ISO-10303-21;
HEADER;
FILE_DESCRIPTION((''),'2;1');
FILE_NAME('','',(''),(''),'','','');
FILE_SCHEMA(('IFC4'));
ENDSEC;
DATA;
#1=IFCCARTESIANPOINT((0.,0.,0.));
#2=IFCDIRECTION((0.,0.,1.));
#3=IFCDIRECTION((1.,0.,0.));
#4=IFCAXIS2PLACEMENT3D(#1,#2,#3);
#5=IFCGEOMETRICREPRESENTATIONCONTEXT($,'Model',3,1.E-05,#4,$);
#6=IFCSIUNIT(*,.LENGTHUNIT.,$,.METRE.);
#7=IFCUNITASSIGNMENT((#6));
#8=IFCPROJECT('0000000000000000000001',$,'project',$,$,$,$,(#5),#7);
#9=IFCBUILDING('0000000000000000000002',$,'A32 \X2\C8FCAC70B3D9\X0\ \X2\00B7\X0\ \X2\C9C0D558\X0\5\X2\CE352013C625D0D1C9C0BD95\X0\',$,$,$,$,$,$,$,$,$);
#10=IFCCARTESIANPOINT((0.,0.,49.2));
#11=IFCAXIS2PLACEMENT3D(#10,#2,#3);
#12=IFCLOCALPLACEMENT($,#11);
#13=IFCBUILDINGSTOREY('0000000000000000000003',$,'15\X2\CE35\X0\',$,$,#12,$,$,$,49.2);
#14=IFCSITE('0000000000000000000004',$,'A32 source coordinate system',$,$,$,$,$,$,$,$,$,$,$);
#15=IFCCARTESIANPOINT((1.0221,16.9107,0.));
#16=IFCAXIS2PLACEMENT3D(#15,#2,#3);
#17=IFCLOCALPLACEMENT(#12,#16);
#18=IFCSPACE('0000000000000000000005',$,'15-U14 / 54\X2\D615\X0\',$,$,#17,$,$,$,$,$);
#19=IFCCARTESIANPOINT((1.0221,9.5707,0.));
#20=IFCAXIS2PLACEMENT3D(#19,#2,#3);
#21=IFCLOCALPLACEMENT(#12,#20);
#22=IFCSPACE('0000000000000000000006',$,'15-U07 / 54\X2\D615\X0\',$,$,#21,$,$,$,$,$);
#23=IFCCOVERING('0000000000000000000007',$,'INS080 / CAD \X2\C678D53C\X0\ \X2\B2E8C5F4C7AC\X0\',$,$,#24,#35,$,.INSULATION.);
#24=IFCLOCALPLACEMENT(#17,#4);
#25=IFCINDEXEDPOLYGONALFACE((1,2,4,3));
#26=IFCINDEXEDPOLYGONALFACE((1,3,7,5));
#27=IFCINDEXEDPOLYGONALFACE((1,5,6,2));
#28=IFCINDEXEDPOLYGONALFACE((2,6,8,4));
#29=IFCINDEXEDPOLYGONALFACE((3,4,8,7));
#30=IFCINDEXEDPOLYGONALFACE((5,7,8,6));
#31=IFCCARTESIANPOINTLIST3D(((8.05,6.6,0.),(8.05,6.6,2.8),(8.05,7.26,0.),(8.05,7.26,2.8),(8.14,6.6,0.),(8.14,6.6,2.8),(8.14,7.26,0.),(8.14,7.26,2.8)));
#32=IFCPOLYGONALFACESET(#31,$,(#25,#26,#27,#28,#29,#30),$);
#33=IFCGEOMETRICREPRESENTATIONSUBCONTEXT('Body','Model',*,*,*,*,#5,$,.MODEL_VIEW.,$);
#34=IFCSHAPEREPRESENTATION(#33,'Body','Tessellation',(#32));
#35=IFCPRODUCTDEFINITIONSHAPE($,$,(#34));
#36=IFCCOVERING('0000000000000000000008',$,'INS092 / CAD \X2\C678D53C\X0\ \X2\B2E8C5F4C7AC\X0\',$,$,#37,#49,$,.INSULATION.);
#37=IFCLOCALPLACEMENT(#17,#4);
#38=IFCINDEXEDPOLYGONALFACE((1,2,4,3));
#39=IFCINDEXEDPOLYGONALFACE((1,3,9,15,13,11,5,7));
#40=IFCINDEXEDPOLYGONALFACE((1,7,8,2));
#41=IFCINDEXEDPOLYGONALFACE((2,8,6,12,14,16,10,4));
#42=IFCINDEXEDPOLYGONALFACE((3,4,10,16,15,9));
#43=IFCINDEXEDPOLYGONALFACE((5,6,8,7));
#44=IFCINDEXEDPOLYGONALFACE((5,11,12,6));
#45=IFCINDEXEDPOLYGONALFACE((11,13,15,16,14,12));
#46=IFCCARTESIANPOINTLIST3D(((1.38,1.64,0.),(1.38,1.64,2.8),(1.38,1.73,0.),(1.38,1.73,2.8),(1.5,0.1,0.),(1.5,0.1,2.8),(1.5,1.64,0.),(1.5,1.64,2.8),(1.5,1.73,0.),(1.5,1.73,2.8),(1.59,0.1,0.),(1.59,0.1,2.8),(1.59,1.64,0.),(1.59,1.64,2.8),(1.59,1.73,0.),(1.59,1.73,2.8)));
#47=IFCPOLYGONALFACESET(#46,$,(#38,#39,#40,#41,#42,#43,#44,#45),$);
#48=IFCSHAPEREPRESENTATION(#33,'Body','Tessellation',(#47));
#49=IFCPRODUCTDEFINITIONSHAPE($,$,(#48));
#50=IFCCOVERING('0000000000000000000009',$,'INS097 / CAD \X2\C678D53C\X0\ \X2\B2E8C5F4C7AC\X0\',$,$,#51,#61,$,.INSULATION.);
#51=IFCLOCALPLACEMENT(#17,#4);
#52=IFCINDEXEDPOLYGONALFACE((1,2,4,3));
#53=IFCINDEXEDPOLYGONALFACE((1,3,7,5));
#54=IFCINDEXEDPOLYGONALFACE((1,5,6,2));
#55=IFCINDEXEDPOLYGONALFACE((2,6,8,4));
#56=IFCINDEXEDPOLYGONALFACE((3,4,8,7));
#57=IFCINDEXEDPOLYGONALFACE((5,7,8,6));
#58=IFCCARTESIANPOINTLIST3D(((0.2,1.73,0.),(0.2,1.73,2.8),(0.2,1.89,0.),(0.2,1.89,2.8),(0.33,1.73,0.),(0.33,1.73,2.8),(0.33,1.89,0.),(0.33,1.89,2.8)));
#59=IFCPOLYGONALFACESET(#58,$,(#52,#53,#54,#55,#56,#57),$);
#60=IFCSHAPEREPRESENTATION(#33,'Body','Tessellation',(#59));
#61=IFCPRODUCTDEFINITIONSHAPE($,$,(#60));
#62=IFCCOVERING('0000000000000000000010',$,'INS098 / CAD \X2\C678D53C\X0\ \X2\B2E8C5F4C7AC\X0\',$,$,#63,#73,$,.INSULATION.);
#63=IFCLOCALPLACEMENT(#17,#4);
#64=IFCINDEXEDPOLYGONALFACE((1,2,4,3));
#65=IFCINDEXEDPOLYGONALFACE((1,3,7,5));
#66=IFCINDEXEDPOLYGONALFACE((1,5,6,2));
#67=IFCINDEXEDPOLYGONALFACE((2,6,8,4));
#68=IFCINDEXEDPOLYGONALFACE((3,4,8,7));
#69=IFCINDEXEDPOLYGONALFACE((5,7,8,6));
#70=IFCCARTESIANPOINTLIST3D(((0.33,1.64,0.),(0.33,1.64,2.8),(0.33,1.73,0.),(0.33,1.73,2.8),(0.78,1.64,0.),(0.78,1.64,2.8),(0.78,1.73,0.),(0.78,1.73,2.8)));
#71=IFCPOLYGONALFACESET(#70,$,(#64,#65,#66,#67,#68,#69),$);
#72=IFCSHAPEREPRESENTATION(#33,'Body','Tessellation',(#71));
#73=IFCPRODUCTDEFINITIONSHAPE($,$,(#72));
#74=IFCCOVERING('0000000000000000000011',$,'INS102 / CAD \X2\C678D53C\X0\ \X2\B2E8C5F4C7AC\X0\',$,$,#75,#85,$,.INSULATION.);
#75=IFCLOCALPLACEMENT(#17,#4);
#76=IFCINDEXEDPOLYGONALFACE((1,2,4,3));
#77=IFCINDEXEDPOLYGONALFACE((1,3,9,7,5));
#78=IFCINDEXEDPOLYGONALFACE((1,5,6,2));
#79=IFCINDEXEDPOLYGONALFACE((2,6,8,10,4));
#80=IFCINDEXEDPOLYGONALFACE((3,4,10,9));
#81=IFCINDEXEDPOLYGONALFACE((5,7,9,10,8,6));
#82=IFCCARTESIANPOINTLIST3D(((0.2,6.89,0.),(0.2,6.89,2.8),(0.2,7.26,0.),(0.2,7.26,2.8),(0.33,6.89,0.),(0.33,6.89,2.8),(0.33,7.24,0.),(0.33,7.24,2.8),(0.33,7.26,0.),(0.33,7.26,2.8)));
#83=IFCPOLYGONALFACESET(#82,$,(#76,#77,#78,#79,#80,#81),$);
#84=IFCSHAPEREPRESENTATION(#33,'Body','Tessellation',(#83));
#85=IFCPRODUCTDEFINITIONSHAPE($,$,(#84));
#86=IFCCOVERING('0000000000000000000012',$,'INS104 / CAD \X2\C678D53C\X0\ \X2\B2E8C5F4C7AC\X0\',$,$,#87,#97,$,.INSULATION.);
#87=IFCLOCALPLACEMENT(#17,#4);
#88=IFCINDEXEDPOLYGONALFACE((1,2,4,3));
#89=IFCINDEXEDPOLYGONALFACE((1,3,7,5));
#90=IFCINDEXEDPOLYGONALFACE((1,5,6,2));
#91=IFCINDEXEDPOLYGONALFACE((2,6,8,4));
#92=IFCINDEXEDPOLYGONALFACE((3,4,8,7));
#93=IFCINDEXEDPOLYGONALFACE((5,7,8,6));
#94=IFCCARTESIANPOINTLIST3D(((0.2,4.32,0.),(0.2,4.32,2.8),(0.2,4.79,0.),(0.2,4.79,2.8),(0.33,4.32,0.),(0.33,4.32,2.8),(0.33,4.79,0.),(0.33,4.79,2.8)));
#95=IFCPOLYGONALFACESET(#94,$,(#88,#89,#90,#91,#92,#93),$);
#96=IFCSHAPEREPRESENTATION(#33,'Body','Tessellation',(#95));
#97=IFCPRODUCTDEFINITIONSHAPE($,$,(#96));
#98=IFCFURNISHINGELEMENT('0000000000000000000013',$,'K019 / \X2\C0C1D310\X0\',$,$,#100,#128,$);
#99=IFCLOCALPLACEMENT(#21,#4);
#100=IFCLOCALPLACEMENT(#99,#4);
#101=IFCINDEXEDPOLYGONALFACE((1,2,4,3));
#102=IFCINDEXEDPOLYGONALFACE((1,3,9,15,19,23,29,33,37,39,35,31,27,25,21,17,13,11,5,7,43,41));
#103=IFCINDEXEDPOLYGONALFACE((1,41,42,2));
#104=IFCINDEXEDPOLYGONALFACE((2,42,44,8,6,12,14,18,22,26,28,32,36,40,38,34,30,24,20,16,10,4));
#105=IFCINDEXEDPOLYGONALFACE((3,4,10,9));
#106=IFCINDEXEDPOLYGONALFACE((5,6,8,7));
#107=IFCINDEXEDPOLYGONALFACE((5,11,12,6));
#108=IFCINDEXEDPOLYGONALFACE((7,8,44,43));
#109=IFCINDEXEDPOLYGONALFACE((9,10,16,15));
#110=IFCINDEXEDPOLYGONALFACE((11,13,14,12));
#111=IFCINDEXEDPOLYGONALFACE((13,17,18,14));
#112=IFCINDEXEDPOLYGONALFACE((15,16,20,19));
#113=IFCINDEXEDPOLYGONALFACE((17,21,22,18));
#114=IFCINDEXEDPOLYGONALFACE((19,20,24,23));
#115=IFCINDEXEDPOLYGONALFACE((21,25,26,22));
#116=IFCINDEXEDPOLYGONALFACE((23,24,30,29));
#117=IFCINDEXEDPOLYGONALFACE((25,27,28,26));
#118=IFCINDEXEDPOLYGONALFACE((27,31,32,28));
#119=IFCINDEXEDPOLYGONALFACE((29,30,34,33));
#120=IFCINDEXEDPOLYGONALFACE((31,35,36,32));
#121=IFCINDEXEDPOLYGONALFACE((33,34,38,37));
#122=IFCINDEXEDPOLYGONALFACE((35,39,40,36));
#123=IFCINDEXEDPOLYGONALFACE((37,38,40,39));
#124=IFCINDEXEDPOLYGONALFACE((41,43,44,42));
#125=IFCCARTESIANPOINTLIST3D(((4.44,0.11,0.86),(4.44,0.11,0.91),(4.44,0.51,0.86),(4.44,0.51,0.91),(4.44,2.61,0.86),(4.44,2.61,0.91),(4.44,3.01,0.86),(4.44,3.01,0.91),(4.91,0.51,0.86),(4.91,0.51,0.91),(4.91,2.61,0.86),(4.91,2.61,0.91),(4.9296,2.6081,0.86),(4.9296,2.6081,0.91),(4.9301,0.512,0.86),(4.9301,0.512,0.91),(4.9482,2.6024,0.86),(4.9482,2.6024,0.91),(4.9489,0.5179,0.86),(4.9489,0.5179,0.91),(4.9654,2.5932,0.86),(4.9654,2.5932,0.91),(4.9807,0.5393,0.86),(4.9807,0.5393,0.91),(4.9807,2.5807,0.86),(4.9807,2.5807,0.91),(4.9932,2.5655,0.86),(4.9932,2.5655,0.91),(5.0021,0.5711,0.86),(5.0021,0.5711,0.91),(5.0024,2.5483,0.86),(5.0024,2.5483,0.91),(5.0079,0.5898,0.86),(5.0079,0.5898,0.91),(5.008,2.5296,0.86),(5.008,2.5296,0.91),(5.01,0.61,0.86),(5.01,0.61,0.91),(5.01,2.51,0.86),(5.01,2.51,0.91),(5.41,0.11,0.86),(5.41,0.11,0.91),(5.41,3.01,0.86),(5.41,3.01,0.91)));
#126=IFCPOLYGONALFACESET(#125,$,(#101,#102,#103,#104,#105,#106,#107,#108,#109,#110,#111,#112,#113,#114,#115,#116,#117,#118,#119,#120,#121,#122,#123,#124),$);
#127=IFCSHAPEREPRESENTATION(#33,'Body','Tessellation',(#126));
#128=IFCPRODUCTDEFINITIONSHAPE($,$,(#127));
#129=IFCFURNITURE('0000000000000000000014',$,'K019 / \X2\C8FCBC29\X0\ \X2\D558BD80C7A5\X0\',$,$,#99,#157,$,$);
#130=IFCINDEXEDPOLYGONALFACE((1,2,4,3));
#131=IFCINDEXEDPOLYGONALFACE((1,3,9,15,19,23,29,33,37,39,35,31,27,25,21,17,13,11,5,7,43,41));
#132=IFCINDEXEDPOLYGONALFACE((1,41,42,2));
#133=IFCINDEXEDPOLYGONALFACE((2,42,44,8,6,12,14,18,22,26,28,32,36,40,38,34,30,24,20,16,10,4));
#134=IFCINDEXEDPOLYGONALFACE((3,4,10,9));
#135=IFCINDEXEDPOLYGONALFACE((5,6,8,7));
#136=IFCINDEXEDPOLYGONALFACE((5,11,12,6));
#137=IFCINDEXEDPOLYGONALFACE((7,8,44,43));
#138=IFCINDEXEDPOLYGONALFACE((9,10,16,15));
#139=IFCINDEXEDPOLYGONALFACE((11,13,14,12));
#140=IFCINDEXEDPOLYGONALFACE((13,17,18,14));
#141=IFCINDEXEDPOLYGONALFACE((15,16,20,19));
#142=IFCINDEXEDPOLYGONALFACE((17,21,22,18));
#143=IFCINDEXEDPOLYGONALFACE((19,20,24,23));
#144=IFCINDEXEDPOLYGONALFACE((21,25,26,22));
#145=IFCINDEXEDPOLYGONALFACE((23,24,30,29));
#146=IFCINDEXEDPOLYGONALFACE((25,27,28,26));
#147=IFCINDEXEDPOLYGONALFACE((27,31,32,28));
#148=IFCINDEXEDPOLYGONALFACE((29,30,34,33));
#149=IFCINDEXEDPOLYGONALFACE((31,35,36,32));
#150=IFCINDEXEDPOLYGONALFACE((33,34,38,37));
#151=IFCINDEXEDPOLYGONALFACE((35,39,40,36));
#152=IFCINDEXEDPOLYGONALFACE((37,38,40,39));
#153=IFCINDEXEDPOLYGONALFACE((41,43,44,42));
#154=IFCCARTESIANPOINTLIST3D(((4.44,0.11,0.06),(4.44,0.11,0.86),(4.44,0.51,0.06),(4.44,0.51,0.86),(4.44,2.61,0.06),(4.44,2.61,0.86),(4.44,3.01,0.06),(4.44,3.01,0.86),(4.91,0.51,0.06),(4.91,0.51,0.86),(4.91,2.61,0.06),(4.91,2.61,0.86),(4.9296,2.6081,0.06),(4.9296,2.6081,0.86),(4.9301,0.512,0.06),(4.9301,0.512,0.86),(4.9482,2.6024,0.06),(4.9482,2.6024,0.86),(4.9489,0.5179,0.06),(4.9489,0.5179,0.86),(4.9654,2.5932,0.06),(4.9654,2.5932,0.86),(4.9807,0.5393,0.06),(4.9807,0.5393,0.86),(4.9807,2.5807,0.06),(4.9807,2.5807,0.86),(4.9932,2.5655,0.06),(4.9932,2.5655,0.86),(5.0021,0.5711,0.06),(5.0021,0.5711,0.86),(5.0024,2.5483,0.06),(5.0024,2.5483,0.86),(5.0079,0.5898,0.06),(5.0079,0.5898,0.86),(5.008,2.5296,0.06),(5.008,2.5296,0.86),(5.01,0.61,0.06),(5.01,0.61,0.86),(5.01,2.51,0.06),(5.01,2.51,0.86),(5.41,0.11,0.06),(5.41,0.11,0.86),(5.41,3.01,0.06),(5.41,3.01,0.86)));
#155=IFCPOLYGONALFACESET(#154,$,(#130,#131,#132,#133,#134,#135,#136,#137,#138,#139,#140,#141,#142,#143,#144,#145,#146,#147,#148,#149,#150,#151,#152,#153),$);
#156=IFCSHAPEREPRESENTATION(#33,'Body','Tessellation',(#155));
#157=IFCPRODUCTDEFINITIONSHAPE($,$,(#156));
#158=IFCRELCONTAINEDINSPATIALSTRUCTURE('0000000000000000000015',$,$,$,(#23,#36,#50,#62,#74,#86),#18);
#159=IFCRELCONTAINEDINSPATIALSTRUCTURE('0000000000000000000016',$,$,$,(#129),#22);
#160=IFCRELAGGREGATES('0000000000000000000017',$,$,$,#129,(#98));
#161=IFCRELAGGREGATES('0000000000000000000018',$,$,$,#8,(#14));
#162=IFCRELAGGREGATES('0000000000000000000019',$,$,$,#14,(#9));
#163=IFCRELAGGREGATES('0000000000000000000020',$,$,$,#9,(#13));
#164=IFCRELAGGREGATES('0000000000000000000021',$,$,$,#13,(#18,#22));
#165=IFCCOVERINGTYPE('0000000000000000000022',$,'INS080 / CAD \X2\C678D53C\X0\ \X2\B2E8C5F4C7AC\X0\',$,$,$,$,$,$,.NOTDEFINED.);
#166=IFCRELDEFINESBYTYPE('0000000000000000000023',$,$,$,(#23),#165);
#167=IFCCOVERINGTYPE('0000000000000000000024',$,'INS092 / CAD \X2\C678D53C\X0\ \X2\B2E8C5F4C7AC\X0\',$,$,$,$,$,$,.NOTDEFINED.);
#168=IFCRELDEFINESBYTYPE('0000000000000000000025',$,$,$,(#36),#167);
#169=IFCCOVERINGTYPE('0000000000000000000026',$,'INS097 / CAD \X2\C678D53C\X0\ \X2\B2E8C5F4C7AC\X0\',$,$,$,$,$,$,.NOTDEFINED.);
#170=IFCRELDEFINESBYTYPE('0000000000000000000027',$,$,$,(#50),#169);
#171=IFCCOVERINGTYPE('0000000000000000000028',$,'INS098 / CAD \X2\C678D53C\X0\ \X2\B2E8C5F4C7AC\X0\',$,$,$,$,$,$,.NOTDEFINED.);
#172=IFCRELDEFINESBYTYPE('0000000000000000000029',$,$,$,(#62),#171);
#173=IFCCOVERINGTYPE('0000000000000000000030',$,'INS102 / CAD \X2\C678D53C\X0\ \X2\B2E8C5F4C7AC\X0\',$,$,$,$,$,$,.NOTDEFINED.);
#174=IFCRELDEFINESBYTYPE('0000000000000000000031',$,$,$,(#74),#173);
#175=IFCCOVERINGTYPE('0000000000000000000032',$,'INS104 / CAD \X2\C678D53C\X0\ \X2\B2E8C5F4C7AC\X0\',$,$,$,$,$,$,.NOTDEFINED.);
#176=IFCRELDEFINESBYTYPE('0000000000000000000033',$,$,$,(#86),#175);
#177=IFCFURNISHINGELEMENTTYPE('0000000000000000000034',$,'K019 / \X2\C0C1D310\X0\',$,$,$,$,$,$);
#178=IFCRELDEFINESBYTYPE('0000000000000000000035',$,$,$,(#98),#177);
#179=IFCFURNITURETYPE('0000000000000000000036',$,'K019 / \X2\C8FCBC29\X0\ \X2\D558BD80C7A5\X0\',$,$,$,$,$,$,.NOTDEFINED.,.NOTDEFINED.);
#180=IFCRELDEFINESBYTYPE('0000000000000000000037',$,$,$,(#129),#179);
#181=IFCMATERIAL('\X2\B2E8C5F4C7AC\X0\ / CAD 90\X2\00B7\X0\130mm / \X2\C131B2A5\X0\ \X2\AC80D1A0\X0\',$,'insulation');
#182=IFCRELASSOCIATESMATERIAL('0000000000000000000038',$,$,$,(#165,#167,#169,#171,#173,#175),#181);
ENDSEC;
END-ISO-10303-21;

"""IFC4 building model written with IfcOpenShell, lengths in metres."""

from ifc_helpers import new_model, si_unit, frame, origin, origin_with_axes, place, context, subcontext, project, spatial, polyline, outline, extrude, source, transform, mapped, material, type_object, type_shapes, element, aggregate, save


model = new_model("IFC4")

# Units and contexts
model_context = context("Model", 3, precision=1e-05, world=origin_with_axes())
body_context = subcontext(model_context, "Body", "Model", "MODEL_VIEW")
ifc_project = project(units=[si_unit("LENGTHUNIT", "METRE")], contexts=[model_context])

# Site, building, storey, space
storey_placement = place(None, frame((0.0, 0.0, 49.2), z_axis=(0.0, 0.0, 1.0), x_axis=(1.0, 0.0, 0.0)))
space_1_placement = place(storey_placement, frame((1.0221, 16.9107, 0.0), z_axis=(0.0, 0.0, 1.0), x_axis=(1.0, 0.0, 0.0)))
site = spatial("IfcSite", under=ifc_project, Name="A32 source coordinate system")
building = spatial("IfcBuilding", under=site, Name="A32 주거동 · 지하5층–옥탑지붕")
storey = spatial("IfcBuildingStorey", under=building, at=storey_placement, Name="15층", Elevation=49.2)
space_1 = spatial("IfcSpace", under=storey, at=space_1_placement, Name="15-U14 / 54형")

# Coverings
ifc_material = material(Name="단열재 / CAD 90·130mm / 성능 검토", Category="insulation")
covering_type_1 = type_object("IfcCoveringType", Name="INS080 / CAD 외피 단열재", PredefinedType="NOTDEFINED", material=ifc_material)
shared_shape_1 = source(origin(), body_context, "Body", "SweptSolid", [
    extrude(outline(polyline([(8.14, 7.26), (8.14, 6.6), (8.05, 6.6), (8.05, 7.26), (8.14, 7.26)])), origin(), (0.0, 0.0, 1.0), 2.8),
])
type_shapes(covering_type_1, [shared_shape_1])
covering_1_placement = place(space_1_placement, origin_with_axes())
element("IfcCovering", 1, at=covering_1_placement, inside=space_1, type_object=covering_type_1, Name="INS080 / CAD 외피 단열재", PredefinedType="INSULATION", context=body_context, shape_type="MappedRepresentation", body=[
    mapped(shared_shape_1, transform((0.0, 0.0, 0.0), scale=1.0)),
])
covering_type_2 = type_object("IfcCoveringType", Name="INS092 / CAD 외피 단열재", PredefinedType="NOTDEFINED", material=ifc_material)
shared_shape_2 = source(origin(), body_context, "Body", "SweptSolid", [
    extrude(outline(polyline([(1.59, 1.73), (1.59, 1.64), (1.59, 0.1), (1.5, 0.1), (1.5, 1.64), (1.38, 1.64), (1.38, 1.73), (1.5, 1.73), (1.59, 1.73)])), origin(), (0.0, 0.0, 1.0), 2.8),
])
type_shapes(covering_type_2, [shared_shape_2])
covering_2_placement = place(space_1_placement, origin_with_axes())
element("IfcCovering", 2, at=covering_2_placement, inside=space_1, type_object=covering_type_2, Name="INS092 / CAD 외피 단열재", PredefinedType="INSULATION", context=body_context, shape_type="MappedRepresentation", body=[
    mapped(shared_shape_2, transform((0.0, 0.0, 0.0), scale=1.0)),
])
covering_type_3 = type_object("IfcCoveringType", Name="INS097 / CAD 외피 단열재", PredefinedType="NOTDEFINED", material=ifc_material)
shared_shape_3 = source(origin(), body_context, "Body", "SweptSolid", [
    extrude(outline(polyline([(0.33, 1.89), (0.33, 1.73), (0.2, 1.73), (0.2, 1.89), (0.33, 1.89)])), origin(), (0.0, 0.0, 1.0), 2.8),
])
type_shapes(covering_type_3, [shared_shape_3])
covering_3_placement = place(space_1_placement, origin_with_axes())
element("IfcCovering", 3, at=covering_3_placement, inside=space_1, type_object=covering_type_3, Name="INS097 / CAD 외피 단열재", PredefinedType="INSULATION", context=body_context, shape_type="MappedRepresentation", body=[
    mapped(shared_shape_3, transform((0.0, 0.0, 0.0), scale=1.0)),
])
covering_type_4 = type_object("IfcCoveringType", Name="INS098 / CAD 외피 단열재", PredefinedType="NOTDEFINED", material=ifc_material)
shared_shape_4 = source(origin(), body_context, "Body", "SweptSolid", [
    extrude(outline(polyline([(0.78, 1.73), (0.78, 1.64), (0.33, 1.64), (0.33, 1.73), (0.78, 1.73)])), origin(), (0.0, 0.0, 1.0), 2.8),
])
type_shapes(covering_type_4, [shared_shape_4])
covering_4_placement = place(space_1_placement, origin_with_axes())
element("IfcCovering", 4, at=covering_4_placement, inside=space_1, type_object=covering_type_4, Name="INS098 / CAD 외피 단열재", PredefinedType="INSULATION", context=body_context, shape_type="MappedRepresentation", body=[
    mapped(shared_shape_4, transform((0.0, 0.0, 0.0), scale=1.0)),
])
covering_type_5 = type_object("IfcCoveringType", Name="INS102 / CAD 외피 단열재", PredefinedType="NOTDEFINED", material=ifc_material)
shared_shape_5 = source(origin(), body_context, "Body", "SweptSolid", [
    extrude(outline(polyline([(0.33, 7.26), (0.33, 7.24), (0.33, 6.89), (0.2, 6.89), (0.2, 7.26), (0.33, 7.26)])), origin(), (0.0, 0.0, 1.0), 2.8),
])
type_shapes(covering_type_5, [shared_shape_5])
covering_5_placement = place(space_1_placement, origin_with_axes())
element("IfcCovering", 5, at=covering_5_placement, inside=space_1, type_object=covering_type_5, Name="INS102 / CAD 외피 단열재", PredefinedType="INSULATION", context=body_context, shape_type="MappedRepresentation", body=[
    mapped(shared_shape_5, transform((0.0, 0.0, 0.0), scale=1.0)),
])
covering_type_6 = type_object("IfcCoveringType", Name="INS104 / CAD 외피 단열재", PredefinedType="NOTDEFINED", material=ifc_material)
shared_shape_6 = source(origin(), body_context, "Body", "SweptSolid", [
    extrude(outline(polyline([(0.33, 4.32), (0.2, 4.32), (0.2, 4.79), (0.33, 4.79), (0.33, 4.32)])), origin(), (0.0, 0.0, 1.0), 2.8),
])
type_shapes(covering_type_6, [shared_shape_6])
covering_6_placement = place(space_1_placement, origin_with_axes())
element("IfcCovering", 6, at=covering_6_placement, inside=space_1, type_object=covering_type_6, Name="INS104 / CAD 외피 단열재", PredefinedType="INSULATION", context=body_context, shape_type="MappedRepresentation", body=[
    mapped(shared_shape_6, transform((0.0, 0.0, 0.0), scale=1.0)),
])

# Furnishing element
furnishing_element_type = type_object("IfcFurnishingElementType", Name="K019 / 상판")
shared_shape_7 = source(origin(), body_context, "Body", "SweptSolid", [
    extrude(outline(polyline([(4.91, 0.51), (4.9301, 0.512), (4.9489, 0.5179), (4.9807, 0.5393), (5.0021, 0.5711), (5.0079, 0.5898), (5.01, 0.61), (5.01, 2.51), (5.008, 2.5296), (5.0024, 2.5483), (4.9932, 2.5655), (4.9807, 2.5807), (4.9654, 2.5932), (4.9482, 2.6024), (4.9296, 2.6081), (4.91, 2.61), (4.44, 2.61), (4.44, 3.01), (5.41, 3.01), (5.41, 0.11), (4.44, 0.11), (4.44, 0.51), (4.91, 0.51)])), frame((0.0, 0.0, 0.86)), (0.0, 0.0, 1.0), 0.05),
])
type_shapes(furnishing_element_type, [shared_shape_7])
space_2_placement = place(storey_placement, frame((1.0221, 9.5707, 0.0), z_axis=(0.0, 0.0, 1.0), x_axis=(1.0, 0.0, 0.0)))
furniture_placement = place(space_2_placement, origin_with_axes())
furnishing_placement = place(furniture_placement, origin_with_axes())
furnishing = element("IfcFurnishingElement", 7, at=furnishing_placement, type_object=furnishing_element_type, Name="K019 / 상판", context=body_context, shape_type="MappedRepresentation", body=[
    mapped(shared_shape_7, transform((0.0, 0.0, 0.0), scale=1.0)),
])

# Shared definitions
space_2 = spatial("IfcSpace", under=storey, at=space_2_placement, Name="15-U07 / 54형")

# Furniture
furniture_type = type_object("IfcFurnitureType", Name="K019 / 주방 하부장", AssemblyPlace="NOTDEFINED", PredefinedType="NOTDEFINED")
shared_shape_8 = source(origin(), body_context, "Body", "SweptSolid", [
    extrude(outline(polyline([(4.44, 0.51), (4.91, 0.51), (4.9301, 0.512), (4.9489, 0.5179), (4.9807, 0.5393), (5.0021, 0.5711), (5.0079, 0.5898), (5.01, 0.61), (5.01, 2.51), (5.008, 2.5296), (5.0024, 2.5483), (4.9932, 2.5655), (4.9807, 2.5807), (4.9654, 2.5932), (4.9482, 2.6024), (4.9296, 2.6081), (4.91, 2.61), (4.44, 2.61), (4.44, 3.01), (5.41, 3.01), (5.41, 0.11), (4.44, 0.11), (4.44, 0.51)])), frame((0.0, 0.0, 0.06)), (0.0, 0.0, 1.0), 0.8),
])
type_shapes(furniture_type, [shared_shape_8])
furniture = element("IfcFurniture", 8, at=furniture_placement, inside=space_2, type_object=furniture_type, Name="K019 / 주방 하부장", context=body_context, shape_type="MappedRepresentation", body=[
    mapped(shared_shape_8, transform((0.0, 0.0, 0.0), scale=1.0)),
])
aggregate(furniture, [furnishing])

save(model, "model.ifc")
